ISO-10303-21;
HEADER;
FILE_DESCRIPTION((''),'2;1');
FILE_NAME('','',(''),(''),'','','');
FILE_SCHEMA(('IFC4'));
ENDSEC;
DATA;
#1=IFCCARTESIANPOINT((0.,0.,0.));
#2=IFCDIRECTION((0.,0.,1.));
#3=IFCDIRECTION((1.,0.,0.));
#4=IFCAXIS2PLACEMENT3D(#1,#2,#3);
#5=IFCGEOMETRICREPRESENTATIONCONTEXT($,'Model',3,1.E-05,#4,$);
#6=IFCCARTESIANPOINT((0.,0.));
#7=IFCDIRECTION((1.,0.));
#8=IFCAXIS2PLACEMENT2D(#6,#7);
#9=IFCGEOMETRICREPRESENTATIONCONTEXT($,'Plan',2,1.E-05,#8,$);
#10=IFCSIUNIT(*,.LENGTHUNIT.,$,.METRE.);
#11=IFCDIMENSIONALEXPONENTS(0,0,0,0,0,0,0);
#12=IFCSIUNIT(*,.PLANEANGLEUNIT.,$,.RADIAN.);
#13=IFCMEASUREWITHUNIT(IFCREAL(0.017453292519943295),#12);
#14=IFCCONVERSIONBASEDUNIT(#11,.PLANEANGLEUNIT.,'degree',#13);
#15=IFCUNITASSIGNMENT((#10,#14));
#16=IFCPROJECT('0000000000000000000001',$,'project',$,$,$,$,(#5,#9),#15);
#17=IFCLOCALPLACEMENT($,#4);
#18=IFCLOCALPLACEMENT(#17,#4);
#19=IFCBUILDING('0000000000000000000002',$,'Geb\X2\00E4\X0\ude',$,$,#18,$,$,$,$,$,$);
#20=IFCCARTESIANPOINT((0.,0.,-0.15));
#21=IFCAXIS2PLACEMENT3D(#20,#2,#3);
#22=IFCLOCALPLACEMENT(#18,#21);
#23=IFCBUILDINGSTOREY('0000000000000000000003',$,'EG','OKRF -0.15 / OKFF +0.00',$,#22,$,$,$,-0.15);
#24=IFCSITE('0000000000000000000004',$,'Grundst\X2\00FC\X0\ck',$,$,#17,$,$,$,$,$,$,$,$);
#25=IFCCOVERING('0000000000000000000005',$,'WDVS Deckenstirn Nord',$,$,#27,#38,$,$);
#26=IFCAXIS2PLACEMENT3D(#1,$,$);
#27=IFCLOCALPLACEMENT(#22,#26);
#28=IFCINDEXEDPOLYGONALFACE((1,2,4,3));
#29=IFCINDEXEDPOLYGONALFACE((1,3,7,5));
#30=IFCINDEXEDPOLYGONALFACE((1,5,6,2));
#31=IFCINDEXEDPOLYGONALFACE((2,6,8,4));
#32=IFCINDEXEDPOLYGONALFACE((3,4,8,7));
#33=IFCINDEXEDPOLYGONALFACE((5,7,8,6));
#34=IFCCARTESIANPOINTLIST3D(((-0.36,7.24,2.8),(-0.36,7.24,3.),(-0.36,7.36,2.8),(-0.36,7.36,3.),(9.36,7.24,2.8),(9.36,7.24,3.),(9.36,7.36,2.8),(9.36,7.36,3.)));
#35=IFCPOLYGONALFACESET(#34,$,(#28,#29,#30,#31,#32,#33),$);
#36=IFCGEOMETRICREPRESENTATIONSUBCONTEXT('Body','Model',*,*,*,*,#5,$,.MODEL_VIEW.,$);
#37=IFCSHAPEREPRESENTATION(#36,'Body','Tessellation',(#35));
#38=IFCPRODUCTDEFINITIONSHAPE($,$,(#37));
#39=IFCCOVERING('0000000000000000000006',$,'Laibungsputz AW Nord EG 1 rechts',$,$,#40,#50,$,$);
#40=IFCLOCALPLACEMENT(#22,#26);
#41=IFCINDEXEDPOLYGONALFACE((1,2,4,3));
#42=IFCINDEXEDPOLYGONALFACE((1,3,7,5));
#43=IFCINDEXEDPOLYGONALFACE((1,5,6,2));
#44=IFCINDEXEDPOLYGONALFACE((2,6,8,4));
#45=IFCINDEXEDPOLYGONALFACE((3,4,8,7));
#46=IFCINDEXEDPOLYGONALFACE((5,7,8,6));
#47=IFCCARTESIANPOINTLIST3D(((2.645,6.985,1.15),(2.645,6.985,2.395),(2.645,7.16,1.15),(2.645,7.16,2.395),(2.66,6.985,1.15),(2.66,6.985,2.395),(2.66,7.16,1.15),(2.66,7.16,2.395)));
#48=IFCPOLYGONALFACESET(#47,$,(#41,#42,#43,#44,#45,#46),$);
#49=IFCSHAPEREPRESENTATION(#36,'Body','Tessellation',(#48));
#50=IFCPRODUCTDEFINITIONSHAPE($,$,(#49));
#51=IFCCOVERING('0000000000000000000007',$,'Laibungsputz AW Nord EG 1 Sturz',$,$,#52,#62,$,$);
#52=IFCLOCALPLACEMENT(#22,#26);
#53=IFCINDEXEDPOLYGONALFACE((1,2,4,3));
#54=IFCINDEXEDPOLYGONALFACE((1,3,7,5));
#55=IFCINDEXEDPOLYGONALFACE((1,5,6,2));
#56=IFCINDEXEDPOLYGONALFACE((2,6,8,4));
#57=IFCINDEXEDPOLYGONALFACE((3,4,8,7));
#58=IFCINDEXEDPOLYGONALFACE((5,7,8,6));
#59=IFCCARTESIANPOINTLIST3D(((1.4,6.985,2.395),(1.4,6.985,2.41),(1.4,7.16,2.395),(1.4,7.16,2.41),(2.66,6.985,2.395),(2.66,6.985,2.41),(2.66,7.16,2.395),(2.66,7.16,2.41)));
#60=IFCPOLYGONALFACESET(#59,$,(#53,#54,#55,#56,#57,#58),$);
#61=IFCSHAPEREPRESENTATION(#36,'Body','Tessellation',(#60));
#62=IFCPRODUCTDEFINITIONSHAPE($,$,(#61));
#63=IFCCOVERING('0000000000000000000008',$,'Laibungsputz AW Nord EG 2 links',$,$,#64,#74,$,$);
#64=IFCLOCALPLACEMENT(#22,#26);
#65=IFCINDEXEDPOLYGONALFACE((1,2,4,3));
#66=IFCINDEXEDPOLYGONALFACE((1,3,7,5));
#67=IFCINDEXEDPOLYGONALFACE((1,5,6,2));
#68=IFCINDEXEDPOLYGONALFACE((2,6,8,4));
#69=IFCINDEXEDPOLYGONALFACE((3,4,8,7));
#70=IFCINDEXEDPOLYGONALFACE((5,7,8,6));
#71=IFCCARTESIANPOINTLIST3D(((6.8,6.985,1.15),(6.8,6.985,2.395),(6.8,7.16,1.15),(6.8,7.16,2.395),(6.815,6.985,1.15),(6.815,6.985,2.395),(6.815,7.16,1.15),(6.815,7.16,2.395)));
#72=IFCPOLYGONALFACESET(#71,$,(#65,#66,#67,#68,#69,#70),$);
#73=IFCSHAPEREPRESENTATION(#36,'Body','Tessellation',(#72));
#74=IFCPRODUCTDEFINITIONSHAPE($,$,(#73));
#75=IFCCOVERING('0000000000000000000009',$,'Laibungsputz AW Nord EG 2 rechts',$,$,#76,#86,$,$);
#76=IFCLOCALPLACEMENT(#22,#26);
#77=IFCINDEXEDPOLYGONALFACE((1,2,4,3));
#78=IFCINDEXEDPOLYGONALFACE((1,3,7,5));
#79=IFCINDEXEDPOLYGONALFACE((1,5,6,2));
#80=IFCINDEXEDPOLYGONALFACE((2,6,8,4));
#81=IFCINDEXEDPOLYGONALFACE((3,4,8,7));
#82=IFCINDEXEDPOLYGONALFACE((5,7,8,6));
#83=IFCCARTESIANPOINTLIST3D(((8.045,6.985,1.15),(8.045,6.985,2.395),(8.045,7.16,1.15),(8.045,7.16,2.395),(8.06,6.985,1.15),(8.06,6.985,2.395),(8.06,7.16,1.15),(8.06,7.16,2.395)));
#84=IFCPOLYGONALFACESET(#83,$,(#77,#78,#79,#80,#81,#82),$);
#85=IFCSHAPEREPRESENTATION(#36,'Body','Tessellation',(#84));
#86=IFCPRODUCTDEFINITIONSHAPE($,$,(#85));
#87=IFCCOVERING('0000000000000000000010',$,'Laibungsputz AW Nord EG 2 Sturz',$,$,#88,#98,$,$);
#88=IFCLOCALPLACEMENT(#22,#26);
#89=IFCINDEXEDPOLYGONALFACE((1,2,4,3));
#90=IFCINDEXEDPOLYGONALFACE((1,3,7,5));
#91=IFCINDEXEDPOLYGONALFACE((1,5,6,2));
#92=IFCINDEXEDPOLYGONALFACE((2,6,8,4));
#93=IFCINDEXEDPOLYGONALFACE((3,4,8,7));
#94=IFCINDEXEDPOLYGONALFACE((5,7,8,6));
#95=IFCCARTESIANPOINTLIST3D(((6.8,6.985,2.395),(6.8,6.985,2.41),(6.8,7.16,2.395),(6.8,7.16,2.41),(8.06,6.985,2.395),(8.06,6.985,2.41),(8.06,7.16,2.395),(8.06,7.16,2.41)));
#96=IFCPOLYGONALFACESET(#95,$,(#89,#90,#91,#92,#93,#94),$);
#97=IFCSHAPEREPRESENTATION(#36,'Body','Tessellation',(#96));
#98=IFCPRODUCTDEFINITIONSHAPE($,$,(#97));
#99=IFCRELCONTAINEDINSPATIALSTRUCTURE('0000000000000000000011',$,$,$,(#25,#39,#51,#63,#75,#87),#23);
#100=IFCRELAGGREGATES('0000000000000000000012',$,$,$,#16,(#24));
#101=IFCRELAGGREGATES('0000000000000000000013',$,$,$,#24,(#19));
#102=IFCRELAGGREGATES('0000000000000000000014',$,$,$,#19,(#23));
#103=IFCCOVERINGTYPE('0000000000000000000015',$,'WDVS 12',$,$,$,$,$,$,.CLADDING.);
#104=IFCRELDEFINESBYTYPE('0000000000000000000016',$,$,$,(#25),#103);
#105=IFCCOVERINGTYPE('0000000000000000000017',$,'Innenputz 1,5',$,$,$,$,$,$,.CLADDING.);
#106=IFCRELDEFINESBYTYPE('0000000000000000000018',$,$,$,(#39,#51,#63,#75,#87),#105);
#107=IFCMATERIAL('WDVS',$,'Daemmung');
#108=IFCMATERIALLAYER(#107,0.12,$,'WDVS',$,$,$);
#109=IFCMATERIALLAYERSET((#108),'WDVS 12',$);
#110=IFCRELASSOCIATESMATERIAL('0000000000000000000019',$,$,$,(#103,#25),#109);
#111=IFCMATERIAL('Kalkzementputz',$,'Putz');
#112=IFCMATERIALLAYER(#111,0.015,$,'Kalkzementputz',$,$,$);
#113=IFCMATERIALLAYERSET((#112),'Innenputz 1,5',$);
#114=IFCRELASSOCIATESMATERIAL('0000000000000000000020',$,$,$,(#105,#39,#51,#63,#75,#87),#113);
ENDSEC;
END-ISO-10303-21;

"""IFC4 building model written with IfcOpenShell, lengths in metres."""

from ifc_helpers import new_model, entity, si_unit, converted_unit, frame, origin_with_axes, origin_2d_with_axis, place, context, subcontext, project, spatial, polyline, indexed_curve, outline, extrude, material, layer, layer_set, layer_usage, type_object, element, save


model = new_model("IFC4")

# Units and contexts
model_context = context("Model", 3, precision=1e-05, world=origin_with_axes())
plan_context = context("Plan", 2, precision=1e-05, world=origin_2d_with_axis())
body_context = subcontext(model_context, "Body", "Model", "MODEL_VIEW")
ifc_project = project(units=[si_unit("LENGTHUNIT", "METRE"), converted_unit("PLANEANGLEUNIT", "degree", entity("IfcReal", 0.017453292519943295), si_unit("PLANEANGLEUNIT", "RADIAN"), dimensions=[0, 0, 0, 0, 0, 0, 0])], contexts=[model_context, plan_context])

# Site, building, storey
site_placement = place(None, origin_with_axes())
site = spatial("IfcSite", under=ifc_project, at=site_placement, Name="Grundstück")
building_placement = place(site_placement, origin_with_axes())
building = spatial("IfcBuilding", under=site, at=building_placement, Name="Gebäude")
storey_placement = place(building_placement, frame((0.0, 0.0, -0.15), z_axis=(0.0, 0.0, 1.0), x_axis=(1.0, 0.0, 0.0)))
storey = spatial("IfcBuildingStorey", under=building, at=storey_placement, Name="EG", Description="OKRF -0.15 / OKFF +0.00", Elevation=-0.15)

# Coverings
ifc_material_1 = material(Name="WDVS", Category="Daemmung")
ifc_layer_1 = layer(ifc_material_1, 0.12, Name="WDVS")
ifc_layer_set_1 = layer_set([ifc_layer_1], Name="WDVS 12")
ifc_layer_usage_1 = layer_usage(ifc_layer_set_1, "AXIS2", "POSITIVE", 0.0)
covering_type_1 = type_object("IfcCoveringType", Name="WDVS 12", PredefinedType="CLADDING", material=ifc_layer_set_1)
covering_1_placement = place(storey_placement, frame((-0.36, 7.24, 2.8), z_axis=(0.0, 0.0, 1.0), x_axis=(1.0, 0.0, 0.0)))
element("IfcCovering", 1, at=covering_1_placement, inside=storey, type_object=covering_type_1, material=ifc_layer_usage_1, Name="WDVS Deckenstirn Nord", context=body_context, shape_type="SweptSolid", body=[
    extrude(outline(indexed_curve([(0.0, 0.0), (0.0, 0.12), (9.72, 0.12), (9.72, 0.0), (0.0, 0.0)], self_intersect=False)), origin_with_axes(), (0.0, 0.0, 1.0), 0.2),
])
ifc_material_2 = material(Name="Kalkzementputz", Category="Putz")
ifc_layer_2 = layer(ifc_material_2, 0.015, Name="Kalkzementputz")
ifc_layer_set_2 = layer_set([ifc_layer_2], Name="Innenputz 1,5")
ifc_layer_usage_2 = layer_usage(ifc_layer_set_2, "AXIS1", "POSITIVE", 2.645)
covering_type_2 = type_object("IfcCoveringType", Name="Innenputz 1,5", PredefinedType="CLADDING", material=ifc_layer_set_2)
covering_2_placement = place(storey_placement, frame((0.0, 7.0, 0.0), z_axis=(0.0, 0.0, 1.0), x_axis=(1.0, 0.0, 0.0)))
element("IfcCovering", 2, at=covering_2_placement, inside=storey, type_object=covering_type_2, material=ifc_layer_usage_2, Name="Laibungsputz AW Nord EG 1 rechts", context=body_context, shape_type="SweptSolid", body=[
    extrude(outline(polyline([(-0.015, 1.15), (0.16, 1.15), (0.16, 2.395), (-0.015, 2.395), (-0.015, 1.15)])), frame((2.645, 0.0, 0.0), z_axis=(1.0, 0.0, 0.0), x_axis=(0.0, 1.0, 0.0)), (0.0, 0.0, 1.0), 0.015),
])
ifc_layer_usage_3 = layer_usage(ifc_layer_set_2, "AXIS3", "POSITIVE", 2.395)
covering_3_placement = place(storey_placement, frame((0.0, 7.0, 0.0), z_axis=(0.0, 0.0, 1.0), x_axis=(1.0, 0.0, 0.0)))
element("IfcCovering", 3, at=covering_3_placement, inside=storey, type_object=covering_type_2, material=ifc_layer_usage_3, Name="Laibungsputz AW Nord EG 1 Sturz", context=body_context, shape_type="SweptSolid", body=[
    extrude(outline(polyline([(-0.015, 2.395), (0.16, 2.395), (0.16, 2.41), (-0.015, 2.41), (-0.015, 2.395)])), frame((1.4, 0.0, 0.0), z_axis=(1.0, 0.0, 0.0), x_axis=(0.0, 1.0, 0.0)), (0.0, 0.0, 1.0), 1.26),
])
ifc_layer_usage_4 = layer_usage(ifc_layer_set_2, "AXIS1", "POSITIVE", 6.8)
covering_4_placement = place(storey_placement, frame((0.0, 7.0, 0.0), z_axis=(0.0, 0.0, 1.0), x_axis=(1.0, 0.0, 0.0)))
element("IfcCovering", 4, at=covering_4_placement, inside=storey, type_object=covering_type_2, material=ifc_layer_usage_4, Name="Laibungsputz AW Nord EG 2 links", context=body_context, shape_type="SweptSolid", body=[
    extrude(outline(polyline([(-0.015, 1.15), (0.16, 1.15), (0.16, 2.395), (-0.015, 2.395), (-0.015, 1.15)])), frame((6.8, 0.0, 0.0), z_axis=(1.0, 0.0, 0.0), x_axis=(0.0, 1.0, 0.0)), (0.0, 0.0, 1.0), 0.015),
])
ifc_layer_usage_5 = layer_usage(ifc_layer_set_2, "AXIS1", "POSITIVE", 8.045)
covering_5_placement = place(storey_placement, frame((0.0, 7.0, 0.0), z_axis=(0.0, 0.0, 1.0), x_axis=(1.0, 0.0, 0.0)))
element("IfcCovering", 5, at=covering_5_placement, inside=storey, type_object=covering_type_2, material=ifc_layer_usage_5, Name="Laibungsputz AW Nord EG 2 rechts", context=body_context, shape_type="SweptSolid", body=[
    extrude(outline(polyline([(-0.015, 1.15), (0.16, 1.15), (0.16, 2.395), (-0.015, 2.395), (-0.015, 1.15)])), frame((8.045, 0.0, 0.0), z_axis=(1.0, 0.0, 0.0), x_axis=(0.0, 1.0, 0.0)), (0.0, 0.0, 1.0), 0.015),
])
ifc_layer_usage_6 = layer_usage(ifc_layer_set_2, "AXIS3", "POSITIVE", 2.395)
covering_6_placement = place(storey_placement, frame((0.0, 7.0, 0.0), z_axis=(0.0, 0.0, 1.0), x_axis=(1.0, 0.0, 0.0)))
element("IfcCovering", 6, at=covering_6_placement, inside=storey, type_object=covering_type_2, material=ifc_layer_usage_6, Name="Laibungsputz AW Nord EG 2 Sturz", context=body_context, shape_type="SweptSolid", body=[
    extrude(outline(polyline([(-0.015, 2.395), (0.16, 2.395), (0.16, 2.41), (-0.015, 2.41), (-0.015, 2.395)])), frame((6.8, 0.0, 0.0), z_axis=(1.0, 0.0, 0.0), x_axis=(0.0, 1.0, 0.0)), (0.0, 0.0, 1.0), 1.26),
])

save(model, "model.ifc")
